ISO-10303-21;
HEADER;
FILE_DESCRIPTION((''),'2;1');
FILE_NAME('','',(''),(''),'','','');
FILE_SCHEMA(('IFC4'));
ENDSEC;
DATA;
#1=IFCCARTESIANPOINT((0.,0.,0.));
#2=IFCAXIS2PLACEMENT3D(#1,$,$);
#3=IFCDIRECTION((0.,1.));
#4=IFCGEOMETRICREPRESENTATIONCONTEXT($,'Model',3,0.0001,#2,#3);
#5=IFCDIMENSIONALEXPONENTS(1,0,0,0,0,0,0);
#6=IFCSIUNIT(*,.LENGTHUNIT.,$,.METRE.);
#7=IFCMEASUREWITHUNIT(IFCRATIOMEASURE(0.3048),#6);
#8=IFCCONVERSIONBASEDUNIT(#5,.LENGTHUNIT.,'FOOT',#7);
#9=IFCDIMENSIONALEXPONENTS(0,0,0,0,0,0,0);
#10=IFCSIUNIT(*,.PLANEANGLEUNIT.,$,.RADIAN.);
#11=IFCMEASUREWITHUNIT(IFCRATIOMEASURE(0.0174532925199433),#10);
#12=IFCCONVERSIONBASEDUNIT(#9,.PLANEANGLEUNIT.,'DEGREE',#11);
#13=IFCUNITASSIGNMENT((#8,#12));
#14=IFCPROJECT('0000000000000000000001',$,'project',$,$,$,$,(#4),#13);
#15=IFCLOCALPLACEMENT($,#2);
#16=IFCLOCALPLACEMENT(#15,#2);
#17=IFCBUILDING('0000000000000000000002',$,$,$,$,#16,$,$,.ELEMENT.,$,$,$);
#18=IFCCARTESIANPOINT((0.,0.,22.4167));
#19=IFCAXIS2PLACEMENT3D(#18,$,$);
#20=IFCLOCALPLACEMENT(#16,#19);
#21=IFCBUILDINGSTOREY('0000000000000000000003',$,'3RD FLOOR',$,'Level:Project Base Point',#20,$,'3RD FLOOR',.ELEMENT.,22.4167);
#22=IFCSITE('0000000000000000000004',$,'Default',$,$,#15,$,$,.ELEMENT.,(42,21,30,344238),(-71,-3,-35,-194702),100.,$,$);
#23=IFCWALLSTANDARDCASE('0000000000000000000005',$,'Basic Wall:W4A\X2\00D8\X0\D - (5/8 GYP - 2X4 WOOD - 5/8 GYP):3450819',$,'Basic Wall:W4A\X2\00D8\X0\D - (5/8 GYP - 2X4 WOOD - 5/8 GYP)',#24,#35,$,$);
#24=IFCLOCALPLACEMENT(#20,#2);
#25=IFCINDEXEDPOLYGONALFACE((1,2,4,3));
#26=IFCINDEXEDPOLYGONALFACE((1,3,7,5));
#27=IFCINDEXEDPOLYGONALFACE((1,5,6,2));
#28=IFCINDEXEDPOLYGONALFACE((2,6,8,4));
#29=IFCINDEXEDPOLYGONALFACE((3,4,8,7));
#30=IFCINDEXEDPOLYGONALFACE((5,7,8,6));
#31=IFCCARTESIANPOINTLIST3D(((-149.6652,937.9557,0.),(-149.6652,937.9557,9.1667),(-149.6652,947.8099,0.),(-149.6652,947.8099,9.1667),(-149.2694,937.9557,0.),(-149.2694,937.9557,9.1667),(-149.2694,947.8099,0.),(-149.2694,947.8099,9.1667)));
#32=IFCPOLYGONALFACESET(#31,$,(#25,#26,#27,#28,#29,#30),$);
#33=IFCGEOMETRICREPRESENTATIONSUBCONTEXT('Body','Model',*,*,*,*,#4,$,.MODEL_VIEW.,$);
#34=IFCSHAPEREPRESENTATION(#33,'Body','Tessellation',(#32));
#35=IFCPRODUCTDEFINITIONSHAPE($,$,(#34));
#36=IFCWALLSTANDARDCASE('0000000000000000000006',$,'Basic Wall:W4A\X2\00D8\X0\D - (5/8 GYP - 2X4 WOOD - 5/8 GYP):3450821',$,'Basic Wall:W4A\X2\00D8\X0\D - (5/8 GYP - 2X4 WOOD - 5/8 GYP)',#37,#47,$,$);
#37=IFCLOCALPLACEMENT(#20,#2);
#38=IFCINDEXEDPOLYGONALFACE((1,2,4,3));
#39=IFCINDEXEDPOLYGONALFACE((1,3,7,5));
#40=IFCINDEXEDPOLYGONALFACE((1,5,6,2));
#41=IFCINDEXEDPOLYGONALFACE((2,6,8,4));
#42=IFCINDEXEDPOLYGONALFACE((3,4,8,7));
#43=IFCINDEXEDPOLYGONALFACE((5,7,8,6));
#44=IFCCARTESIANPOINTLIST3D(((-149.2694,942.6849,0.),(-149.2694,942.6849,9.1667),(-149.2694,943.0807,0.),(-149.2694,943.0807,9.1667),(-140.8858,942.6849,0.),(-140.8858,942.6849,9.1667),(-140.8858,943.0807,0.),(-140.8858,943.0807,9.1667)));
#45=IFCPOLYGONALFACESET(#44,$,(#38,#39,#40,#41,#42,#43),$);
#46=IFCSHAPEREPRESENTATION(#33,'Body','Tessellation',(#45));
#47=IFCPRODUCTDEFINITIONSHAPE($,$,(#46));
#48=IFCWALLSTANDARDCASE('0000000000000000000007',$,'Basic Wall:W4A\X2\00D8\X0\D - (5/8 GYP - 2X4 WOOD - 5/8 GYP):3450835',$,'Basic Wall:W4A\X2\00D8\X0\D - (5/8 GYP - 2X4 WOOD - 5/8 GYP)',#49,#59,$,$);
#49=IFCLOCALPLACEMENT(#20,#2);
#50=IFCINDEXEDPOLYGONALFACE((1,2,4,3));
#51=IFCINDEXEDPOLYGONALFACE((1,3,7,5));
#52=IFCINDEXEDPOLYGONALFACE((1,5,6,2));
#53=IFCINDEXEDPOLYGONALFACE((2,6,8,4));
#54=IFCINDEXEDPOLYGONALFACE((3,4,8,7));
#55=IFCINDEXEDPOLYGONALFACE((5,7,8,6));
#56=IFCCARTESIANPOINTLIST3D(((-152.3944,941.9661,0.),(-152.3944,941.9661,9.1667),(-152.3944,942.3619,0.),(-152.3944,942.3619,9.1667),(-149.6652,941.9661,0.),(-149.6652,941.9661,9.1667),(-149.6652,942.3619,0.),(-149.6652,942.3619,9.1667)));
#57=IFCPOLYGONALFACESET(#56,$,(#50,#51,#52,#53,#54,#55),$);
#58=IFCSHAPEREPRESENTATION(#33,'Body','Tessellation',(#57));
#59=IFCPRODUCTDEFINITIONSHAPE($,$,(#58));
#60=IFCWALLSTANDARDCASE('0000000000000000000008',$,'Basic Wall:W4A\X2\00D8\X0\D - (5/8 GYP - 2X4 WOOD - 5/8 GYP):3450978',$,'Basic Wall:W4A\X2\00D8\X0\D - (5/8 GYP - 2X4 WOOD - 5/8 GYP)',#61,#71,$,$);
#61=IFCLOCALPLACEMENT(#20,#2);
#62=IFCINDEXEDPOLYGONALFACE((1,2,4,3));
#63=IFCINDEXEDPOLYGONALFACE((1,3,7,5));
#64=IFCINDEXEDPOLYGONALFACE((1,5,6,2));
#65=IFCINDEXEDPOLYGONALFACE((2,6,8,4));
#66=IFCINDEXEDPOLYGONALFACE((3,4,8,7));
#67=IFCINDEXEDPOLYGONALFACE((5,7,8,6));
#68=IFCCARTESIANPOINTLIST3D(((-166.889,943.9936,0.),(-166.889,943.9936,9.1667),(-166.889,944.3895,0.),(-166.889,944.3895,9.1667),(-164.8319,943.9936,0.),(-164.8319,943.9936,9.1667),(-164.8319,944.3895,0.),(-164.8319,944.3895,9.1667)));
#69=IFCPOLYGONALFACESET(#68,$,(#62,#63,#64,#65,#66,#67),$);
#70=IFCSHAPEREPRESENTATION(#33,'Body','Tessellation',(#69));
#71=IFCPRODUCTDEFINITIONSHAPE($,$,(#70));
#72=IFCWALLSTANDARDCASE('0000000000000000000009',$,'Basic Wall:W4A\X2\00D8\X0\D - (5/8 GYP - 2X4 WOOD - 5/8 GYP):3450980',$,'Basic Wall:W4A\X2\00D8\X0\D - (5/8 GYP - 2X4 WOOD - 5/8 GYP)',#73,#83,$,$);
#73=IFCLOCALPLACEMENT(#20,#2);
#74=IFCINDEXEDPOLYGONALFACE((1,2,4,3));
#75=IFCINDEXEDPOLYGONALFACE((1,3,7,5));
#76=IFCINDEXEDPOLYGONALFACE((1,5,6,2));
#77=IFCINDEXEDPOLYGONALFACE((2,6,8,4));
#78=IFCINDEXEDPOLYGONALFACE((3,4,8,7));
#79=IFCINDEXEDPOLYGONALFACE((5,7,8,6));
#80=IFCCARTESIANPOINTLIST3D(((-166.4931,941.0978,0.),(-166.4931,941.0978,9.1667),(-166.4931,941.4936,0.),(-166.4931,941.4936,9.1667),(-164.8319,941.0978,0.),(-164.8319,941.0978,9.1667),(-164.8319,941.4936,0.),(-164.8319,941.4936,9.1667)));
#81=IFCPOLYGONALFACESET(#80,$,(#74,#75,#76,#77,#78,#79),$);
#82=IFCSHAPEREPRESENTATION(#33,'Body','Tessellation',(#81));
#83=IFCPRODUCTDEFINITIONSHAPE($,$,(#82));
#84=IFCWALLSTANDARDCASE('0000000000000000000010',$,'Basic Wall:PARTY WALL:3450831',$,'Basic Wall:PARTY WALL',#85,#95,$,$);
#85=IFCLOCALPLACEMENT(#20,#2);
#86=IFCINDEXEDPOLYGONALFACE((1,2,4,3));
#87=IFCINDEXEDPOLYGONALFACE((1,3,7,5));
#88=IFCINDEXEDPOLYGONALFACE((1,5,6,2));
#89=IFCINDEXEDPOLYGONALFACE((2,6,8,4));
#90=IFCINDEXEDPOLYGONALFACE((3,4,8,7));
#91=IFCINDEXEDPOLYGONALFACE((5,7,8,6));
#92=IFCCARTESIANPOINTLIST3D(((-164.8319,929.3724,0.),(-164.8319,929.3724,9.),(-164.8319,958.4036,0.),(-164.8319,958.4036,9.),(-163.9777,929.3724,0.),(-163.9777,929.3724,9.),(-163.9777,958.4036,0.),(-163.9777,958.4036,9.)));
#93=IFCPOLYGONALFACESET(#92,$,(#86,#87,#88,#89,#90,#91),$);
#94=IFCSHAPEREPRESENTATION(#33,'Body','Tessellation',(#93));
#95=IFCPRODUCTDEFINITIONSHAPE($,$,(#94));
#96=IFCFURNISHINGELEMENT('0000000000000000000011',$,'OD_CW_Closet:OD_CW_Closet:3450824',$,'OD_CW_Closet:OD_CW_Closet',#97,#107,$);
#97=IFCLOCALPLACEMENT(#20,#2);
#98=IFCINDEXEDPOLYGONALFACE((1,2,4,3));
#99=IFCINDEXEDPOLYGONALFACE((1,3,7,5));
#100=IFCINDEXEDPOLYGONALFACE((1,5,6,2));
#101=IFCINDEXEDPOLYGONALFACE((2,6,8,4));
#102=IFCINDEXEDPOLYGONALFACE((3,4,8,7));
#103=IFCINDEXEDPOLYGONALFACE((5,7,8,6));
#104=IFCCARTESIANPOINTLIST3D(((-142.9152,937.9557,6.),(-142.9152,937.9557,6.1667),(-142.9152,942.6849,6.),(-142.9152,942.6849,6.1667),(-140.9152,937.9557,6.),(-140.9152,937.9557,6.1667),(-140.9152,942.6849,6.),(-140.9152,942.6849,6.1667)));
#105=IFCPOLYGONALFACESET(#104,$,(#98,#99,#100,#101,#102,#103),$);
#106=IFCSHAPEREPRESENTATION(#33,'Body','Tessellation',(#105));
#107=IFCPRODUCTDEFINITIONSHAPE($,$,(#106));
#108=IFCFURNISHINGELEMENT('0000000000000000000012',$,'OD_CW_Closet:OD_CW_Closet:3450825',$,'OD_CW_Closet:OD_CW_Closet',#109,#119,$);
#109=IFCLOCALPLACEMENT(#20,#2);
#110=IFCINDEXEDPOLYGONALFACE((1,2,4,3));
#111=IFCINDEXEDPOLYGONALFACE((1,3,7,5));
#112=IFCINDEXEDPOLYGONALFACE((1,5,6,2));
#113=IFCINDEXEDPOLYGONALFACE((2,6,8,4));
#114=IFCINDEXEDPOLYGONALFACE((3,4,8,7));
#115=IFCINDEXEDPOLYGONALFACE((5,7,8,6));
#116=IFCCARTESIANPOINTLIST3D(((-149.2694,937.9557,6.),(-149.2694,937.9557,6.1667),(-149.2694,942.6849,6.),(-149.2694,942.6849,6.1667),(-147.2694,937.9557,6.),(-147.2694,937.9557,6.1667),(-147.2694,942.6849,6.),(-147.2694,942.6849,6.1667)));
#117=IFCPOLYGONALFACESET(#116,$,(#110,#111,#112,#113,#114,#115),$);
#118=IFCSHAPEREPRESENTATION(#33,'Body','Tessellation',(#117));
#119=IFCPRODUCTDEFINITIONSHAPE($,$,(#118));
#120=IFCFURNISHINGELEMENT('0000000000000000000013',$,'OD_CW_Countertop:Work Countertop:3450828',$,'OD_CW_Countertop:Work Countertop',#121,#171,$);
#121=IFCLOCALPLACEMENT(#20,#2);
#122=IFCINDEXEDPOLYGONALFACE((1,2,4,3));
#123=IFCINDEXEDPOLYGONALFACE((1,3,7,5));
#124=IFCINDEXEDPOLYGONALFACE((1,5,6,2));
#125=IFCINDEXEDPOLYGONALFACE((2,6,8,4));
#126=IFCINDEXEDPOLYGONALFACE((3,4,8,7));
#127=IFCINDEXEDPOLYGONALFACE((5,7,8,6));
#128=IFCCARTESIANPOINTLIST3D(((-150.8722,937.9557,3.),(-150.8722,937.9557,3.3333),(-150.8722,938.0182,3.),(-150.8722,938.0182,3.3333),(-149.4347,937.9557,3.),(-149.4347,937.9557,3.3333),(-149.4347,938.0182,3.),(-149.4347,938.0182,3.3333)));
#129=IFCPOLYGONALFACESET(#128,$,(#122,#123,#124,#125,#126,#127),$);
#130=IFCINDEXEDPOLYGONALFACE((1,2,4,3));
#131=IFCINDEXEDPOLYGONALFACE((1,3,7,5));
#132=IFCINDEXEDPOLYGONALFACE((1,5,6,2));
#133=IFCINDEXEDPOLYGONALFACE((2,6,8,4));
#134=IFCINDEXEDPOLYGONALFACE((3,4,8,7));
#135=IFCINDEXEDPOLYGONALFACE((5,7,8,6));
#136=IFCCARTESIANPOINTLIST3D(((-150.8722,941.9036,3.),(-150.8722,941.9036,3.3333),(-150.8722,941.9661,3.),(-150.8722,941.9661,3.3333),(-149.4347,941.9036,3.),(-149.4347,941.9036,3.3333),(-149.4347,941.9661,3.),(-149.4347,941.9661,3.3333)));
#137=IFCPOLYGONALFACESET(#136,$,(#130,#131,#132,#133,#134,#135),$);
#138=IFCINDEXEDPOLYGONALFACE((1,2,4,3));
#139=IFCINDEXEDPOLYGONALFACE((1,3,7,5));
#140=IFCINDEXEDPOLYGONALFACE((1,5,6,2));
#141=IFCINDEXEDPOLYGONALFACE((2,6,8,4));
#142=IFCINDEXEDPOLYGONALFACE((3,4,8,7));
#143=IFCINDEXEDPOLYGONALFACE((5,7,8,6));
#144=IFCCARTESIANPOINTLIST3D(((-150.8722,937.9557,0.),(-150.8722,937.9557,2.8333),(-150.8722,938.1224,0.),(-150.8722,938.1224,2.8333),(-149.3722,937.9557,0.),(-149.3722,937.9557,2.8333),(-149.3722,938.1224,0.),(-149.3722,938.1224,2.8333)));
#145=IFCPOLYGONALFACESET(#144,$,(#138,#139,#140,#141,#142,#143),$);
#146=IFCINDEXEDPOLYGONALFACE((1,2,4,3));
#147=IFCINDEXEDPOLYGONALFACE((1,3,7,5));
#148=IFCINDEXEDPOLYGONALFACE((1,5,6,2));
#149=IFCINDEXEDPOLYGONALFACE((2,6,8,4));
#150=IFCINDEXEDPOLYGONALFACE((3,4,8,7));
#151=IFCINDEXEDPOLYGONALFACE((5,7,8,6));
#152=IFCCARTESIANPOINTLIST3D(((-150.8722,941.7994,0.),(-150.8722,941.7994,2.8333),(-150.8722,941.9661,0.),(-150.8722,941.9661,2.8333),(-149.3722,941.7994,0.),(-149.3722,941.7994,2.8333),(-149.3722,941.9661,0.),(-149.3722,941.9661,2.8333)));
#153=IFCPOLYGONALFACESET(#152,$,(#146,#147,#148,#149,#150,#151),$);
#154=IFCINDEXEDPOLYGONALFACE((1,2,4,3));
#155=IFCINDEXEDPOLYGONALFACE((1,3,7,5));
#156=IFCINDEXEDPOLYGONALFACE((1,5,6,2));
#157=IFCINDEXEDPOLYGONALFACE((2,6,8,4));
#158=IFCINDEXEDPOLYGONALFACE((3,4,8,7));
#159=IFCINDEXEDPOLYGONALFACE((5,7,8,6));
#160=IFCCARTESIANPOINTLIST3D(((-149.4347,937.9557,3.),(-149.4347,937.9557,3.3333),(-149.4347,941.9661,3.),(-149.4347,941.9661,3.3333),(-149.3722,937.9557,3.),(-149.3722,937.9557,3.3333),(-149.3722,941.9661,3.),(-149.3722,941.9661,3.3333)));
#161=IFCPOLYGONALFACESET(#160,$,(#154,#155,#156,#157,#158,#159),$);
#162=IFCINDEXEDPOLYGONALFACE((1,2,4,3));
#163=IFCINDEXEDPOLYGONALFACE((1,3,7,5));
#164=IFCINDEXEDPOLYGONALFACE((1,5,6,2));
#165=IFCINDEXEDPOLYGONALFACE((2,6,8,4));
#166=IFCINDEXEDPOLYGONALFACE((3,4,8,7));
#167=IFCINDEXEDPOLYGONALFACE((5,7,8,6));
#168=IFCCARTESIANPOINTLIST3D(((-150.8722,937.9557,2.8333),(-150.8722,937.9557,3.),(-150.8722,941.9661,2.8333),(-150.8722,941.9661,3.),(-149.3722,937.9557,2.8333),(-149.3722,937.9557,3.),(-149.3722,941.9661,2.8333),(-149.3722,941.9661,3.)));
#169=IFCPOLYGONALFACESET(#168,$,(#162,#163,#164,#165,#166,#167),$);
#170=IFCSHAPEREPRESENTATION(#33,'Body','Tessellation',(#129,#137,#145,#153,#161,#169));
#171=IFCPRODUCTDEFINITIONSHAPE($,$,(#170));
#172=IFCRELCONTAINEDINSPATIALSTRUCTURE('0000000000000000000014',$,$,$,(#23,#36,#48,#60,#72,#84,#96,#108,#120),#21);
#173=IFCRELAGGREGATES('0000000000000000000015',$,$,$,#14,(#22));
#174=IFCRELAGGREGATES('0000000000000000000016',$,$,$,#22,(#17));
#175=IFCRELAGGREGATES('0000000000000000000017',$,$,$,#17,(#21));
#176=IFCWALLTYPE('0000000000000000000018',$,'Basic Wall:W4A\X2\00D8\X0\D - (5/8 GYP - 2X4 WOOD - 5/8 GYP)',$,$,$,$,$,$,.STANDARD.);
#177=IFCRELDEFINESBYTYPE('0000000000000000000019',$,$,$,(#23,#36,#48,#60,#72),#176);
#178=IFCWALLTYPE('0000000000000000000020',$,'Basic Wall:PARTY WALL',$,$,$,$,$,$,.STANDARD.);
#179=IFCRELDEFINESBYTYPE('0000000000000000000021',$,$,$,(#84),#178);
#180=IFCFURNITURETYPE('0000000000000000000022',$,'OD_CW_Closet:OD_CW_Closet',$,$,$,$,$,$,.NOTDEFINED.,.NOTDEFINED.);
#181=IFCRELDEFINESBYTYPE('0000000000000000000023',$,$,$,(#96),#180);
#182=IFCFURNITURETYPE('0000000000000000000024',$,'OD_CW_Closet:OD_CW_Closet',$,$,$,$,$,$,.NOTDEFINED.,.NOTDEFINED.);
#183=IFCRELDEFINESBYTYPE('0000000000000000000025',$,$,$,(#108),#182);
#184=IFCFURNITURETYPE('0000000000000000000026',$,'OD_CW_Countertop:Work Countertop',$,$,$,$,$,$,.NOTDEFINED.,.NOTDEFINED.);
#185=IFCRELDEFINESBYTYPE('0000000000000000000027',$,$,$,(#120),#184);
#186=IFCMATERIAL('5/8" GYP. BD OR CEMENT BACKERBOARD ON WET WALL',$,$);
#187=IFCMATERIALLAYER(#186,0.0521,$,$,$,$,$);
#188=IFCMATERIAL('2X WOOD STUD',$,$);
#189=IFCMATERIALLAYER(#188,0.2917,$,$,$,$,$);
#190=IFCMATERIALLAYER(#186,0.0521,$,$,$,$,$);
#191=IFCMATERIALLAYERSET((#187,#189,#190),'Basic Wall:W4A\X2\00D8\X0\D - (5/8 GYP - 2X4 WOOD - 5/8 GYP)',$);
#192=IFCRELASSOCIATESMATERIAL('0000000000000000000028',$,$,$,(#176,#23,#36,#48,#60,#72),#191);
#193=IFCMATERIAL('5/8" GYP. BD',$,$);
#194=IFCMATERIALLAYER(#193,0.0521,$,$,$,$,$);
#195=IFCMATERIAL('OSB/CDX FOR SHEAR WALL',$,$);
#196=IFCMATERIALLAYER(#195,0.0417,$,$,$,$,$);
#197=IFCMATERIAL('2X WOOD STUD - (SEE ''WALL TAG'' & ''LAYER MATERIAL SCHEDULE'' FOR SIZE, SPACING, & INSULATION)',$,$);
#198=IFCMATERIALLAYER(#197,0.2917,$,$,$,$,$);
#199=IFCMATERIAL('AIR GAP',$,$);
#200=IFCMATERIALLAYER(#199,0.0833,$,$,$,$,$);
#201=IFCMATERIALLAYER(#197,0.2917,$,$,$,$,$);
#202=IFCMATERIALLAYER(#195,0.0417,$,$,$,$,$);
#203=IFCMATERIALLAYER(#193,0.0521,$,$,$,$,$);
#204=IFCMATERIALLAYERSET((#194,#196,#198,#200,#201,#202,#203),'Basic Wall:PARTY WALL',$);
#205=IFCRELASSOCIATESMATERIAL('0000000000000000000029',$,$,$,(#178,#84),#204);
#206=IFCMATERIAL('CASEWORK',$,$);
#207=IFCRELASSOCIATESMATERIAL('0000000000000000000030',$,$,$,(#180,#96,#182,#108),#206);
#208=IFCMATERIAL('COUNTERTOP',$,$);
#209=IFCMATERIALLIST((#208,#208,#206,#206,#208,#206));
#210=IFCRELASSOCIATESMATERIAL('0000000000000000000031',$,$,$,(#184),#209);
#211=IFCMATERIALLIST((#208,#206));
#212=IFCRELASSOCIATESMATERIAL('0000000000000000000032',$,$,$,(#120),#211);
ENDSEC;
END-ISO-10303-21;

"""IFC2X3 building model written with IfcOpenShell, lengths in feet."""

from ifc_helpers import new_model, entity, si_unit, converted_unit, direction, frame, frame_2d, origin, origin_2d_with_axis, place, context, subcontext, project, spatial, rectangle, extrude, source, transform, mapped, material, material_list, layer, layer_set, layer_usage, type_object, type_shapes, element, save


model = new_model("IFC2X3")

# Units and contexts
model_context = context("Model", 3, precision=0.0001, world=origin(), true_north=direction((0.0, 1.0)))
body_context = subcontext(model_context, "Body", "Model", "MODEL_VIEW")
ifc_project = project(units=[converted_unit("LENGTHUNIT", "FOOT", entity("IfcRatioMeasure", 0.3048), si_unit("LENGTHUNIT", "METRE"), dimensions=[1, 0, 0, 0, 0, 0, 0]), converted_unit("PLANEANGLEUNIT", "DEGREE", entity("IfcRatioMeasure", 0.0174532925199433), si_unit("PLANEANGLEUNIT", "RADIAN"), dimensions=[0, 0, 0, 0, 0, 0, 0])], contexts=[model_context])

# Site, building, storey
site_placement = place(None, origin())
site = spatial("IfcSite", under=ifc_project, at=site_placement, Name="Default", CompositionType="ELEMENT", RefLatitude=(42, 21, 30, 344238), RefLongitude=(-71, -3, -35, -194702), RefElevation=100.0)
building_placement = place(site_placement, origin())
building = spatial("IfcBuilding", under=site, at=building_placement, CompositionType="ELEMENT")
storey_placement = place(building_placement, frame((0.0, 0.0, 22.4167)))
storey = spatial("IfcBuildingStorey", under=building, at=storey_placement, Name="3RD FLOOR", ObjectType="Level:Project Base Point", LongName="3RD FLOOR", CompositionType="ELEMENT", Elevation=22.4167)

# Shared definitions
ifc_material_1 = material(Name="5/8\" GYP. BD OR CEMENT BACKERBOARD ON WET WALL")
ifc_layer_1 = layer(ifc_material_1, 0.0521)
ifc_material_2 = material(Name="2X WOOD STUD")
ifc_layer_2 = layer(ifc_material_2, 0.2917)
ifc_layer_3 = layer(ifc_material_1, 0.0521)
ifc_layer_set_1 = layer_set([ifc_layer_1, ifc_layer_2, ifc_layer_3], Name="Basic Wall:W4AØD - (5/8 GYP - 2X4 WOOD - 5/8 GYP)")
wall_type_1 = type_object("IfcWallType", Name="Basic Wall:W4AØD - (5/8 GYP - 2X4 WOOD - 5/8 GYP)", PredefinedType="STANDARD", material=ifc_layer_set_1)

# Walls
ifc_layer_usage_1 = layer_usage(ifc_layer_set_1, "AXIS2", "POSITIVE", -0.1979)
wall_1_placement = place(storey_placement, frame((-149.4673, 937.9557, 0.0), z_axis=(0.0, 0.0, 1.0), x_axis=(0.0, 1.0, 0.0)))
element("IfcWallStandardCase", 1, at=wall_1_placement, inside=storey, type_object=wall_type_1, material=ifc_layer_usage_1, Name="Basic Wall:W4AØD - (5/8 GYP - 2X4 WOOD - 5/8 GYP):3450819", ObjectType="Basic Wall:W4AØD - (5/8 GYP - 2X4 WOOD - 5/8 GYP)", context=body_context, shape_type="SweptSolid", body=[
    extrude(rectangle(XDim=9.8542, YDim=0.3958, at=frame_2d((4.9271, 0.0), x_axis=(-1.0, 0.0))), origin(), (0.0, 0.0, 1.0), 9.1667),
])
ifc_layer_usage_2 = layer_usage(ifc_layer_set_1, "AXIS2", "NEGATIVE", 0.1979)
wall_2_placement = place(storey_placement, frame((-149.2694, 942.8828, 0.0)))
element("IfcWallStandardCase", 2, at=wall_2_placement, inside=storey, type_object=wall_type_1, material=ifc_layer_usage_2, Name="Basic Wall:W4AØD - (5/8 GYP - 2X4 WOOD - 5/8 GYP):3450821", ObjectType="Basic Wall:W4AØD - (5/8 GYP - 2X4 WOOD - 5/8 GYP)", context=body_context, shape_type="SweptSolid", body=[
    extrude(rectangle(XDim=8.3836, YDim=0.3958, at=frame_2d((4.1918, 0.0), x_axis=(-1.0, 0.0))), origin(), (0.0, 0.0, 1.0), 9.1667),
])
ifc_layer_usage_3 = layer_usage(ifc_layer_set_1, "AXIS2", "POSITIVE", -0.1979)
wall_3_placement = place(storey_placement, frame((-149.6652, 942.164, 0.0), z_axis=(0.0, 0.0, 1.0), x_axis=(-1.0, 0.0, 0.0)))
element("IfcWallStandardCase", 3, at=wall_3_placement, inside=storey, type_object=wall_type_1, material=ifc_layer_usage_3, Name="Basic Wall:W4AØD - (5/8 GYP - 2X4 WOOD - 5/8 GYP):3450835", ObjectType="Basic Wall:W4AØD - (5/8 GYP - 2X4 WOOD - 5/8 GYP)", context=body_context, shape_type="SweptSolid", body=[
    extrude(rectangle(XDim=2.7292, YDim=0.3958, at=frame_2d((1.3646, 0.0), x_axis=(-1.0, 0.0))), origin(), (0.0, 0.0, 1.0), 9.1667),
])
ifc_layer_usage_4 = layer_usage(ifc_layer_set_1, "AXIS2", "POSITIVE", -0.1979)
wall_4_placement = place(storey_placement, frame((-164.8319, 944.1916, 0.0), z_axis=(0.0, 0.0, 1.0), x_axis=(-1.0, 0.0, 0.0)))
element("IfcWallStandardCase", 4, at=wall_4_placement, inside=storey, type_object=wall_type_1, material=ifc_layer_usage_4, Name="Basic Wall:W4AØD - (5/8 GYP - 2X4 WOOD - 5/8 GYP):3450978", ObjectType="Basic Wall:W4AØD - (5/8 GYP - 2X4 WOOD - 5/8 GYP)", context=body_context, shape_type="SweptSolid", body=[
    extrude(rectangle(XDim=2.0571, YDim=0.3958, at=frame_2d((1.0285, 0.0), x_axis=(-1.0, 0.0))), origin(), (0.0, 0.0, 1.0), 9.1667),
])

# Walls
ifc_layer_usage_5 = layer_usage(ifc_layer_set_1, "AXIS2", "POSITIVE", -0.1979)
wall_5_placement = place(storey_placement, frame((-166.4931, 941.2957, 0.0)))
element("IfcWallStandardCase", 5, at=wall_5_placement, inside=storey, type_object=wall_type_1, material=ifc_layer_usage_5, Name="Basic Wall:W4AØD - (5/8 GYP - 2X4 WOOD - 5/8 GYP):3450980", ObjectType="Basic Wall:W4AØD - (5/8 GYP - 2X4 WOOD - 5/8 GYP)", context=body_context, shape_type="SweptSolid", body=[
    extrude(rectangle(XDim=1.6612, YDim=0.3958, at=frame_2d((0.8306, 0.0), x_axis=(-1.0, 0.0))), origin(), (0.0, 0.0, 1.0), 9.1667),
])
ifc_material_3 = material(Name="5/8\" GYP. BD")
ifc_layer_4 = layer(ifc_material_3, 0.0521)
ifc_material_4 = material(Name="OSB/CDX FOR SHEAR WALL")
ifc_layer_5 = layer(ifc_material_4, 0.0417)
ifc_material_5 = material(Name="2X WOOD STUD - (SEE 'WALL TAG' & 'LAYER MATERIAL SCHEDULE' FOR SIZE, SPACING, & INSULATION)")
ifc_layer_6 = layer(ifc_material_5, 0.2917)
ifc_material_6 = material(Name="AIR GAP")
ifc_layer_7 = layer(ifc_material_6, 0.0833)
ifc_layer_8 = layer(ifc_material_5, 0.2917)
ifc_layer_9 = layer(ifc_material_4, 0.0417)
ifc_layer_10 = layer(ifc_material_3, 0.0521)
ifc_layer_set_2 = layer_set([ifc_layer_4, ifc_layer_5, ifc_layer_6, ifc_layer_7, ifc_layer_8, ifc_layer_9, ifc_layer_10], Name="Basic Wall:PARTY WALL")
ifc_layer_usage_6 = layer_usage(ifc_layer_set_2, "AXIS2", "NEGATIVE", 0.4271)
wall_type_2 = type_object("IfcWallType", Name="Basic Wall:PARTY WALL", PredefinedType="STANDARD", material=ifc_layer_set_2)
wall_6_placement = place(storey_placement, frame((-164.4048, 929.3724, 0.0), z_axis=(0.0, 0.0, 1.0), x_axis=(0.0, 1.0, 0.0)))
element("IfcWallStandardCase", 6, at=wall_6_placement, inside=storey, type_object=wall_type_2, material=ifc_layer_usage_6, Name="Basic Wall:PARTY WALL:3450831", ObjectType="Basic Wall:PARTY WALL", context=body_context, shape_type="SweptSolid", body=[
    extrude(rectangle(XDim=29.0313, YDim=0.8542, at=frame_2d((14.5156, 0.0), x_axis=(-1.0, 0.0))), origin(), (0.0, 0.0, 1.0), 9.0),
])

# Furnishing elements
ifc_material_7 = material(Name="CASEWORK")
furniture_type_1 = type_object("IfcFurnitureType", Name="OD_CW_Closet:OD_CW_Closet", material=ifc_material_7)
shared_shape_1 = source(origin(), body_context, "Body", "SweptSolid", [
    extrude(rectangle(XDim=4.7292, YDim=2.0, at=origin_2d_with_axis()), frame((2.3646, 1.0, 0.0)), (0.0, 0.0, 1.0), 0.1667),
])
type_shapes(furniture_type_1, [shared_shape_1])
furnishing_1_placement = place(storey_placement, frame((-140.9152, 937.9557, 6.0), z_axis=(0.0, 0.0, 1.0), x_axis=(0.0, 1.0, 0.0)))
element("IfcFurnishingElement", 7, at=furnishing_1_placement, inside=storey, type_object=furniture_type_1, material=ifc_material_7, Name="OD_CW_Closet:OD_CW_Closet:3450824", ObjectType="OD_CW_Closet:OD_CW_Closet", context=body_context, shape_type="MappedRepresentation", body=[
    mapped(shared_shape_1, transform((0.0, 0.0, 0.0), scale=1.0)),
])
furniture_type_2 = type_object("IfcFurnitureType", Name="OD_CW_Closet:OD_CW_Closet", material=ifc_material_7)
shared_shape_2 = source(origin(), body_context, "Body", "SweptSolid", [
    extrude(rectangle(XDim=2.0, YDim=4.7292, at=origin_2d_with_axis()), frame((2.3646, 1.0, 0.0), z_axis=(0.0, 0.0, 1.0), x_axis=(0.0, -1.0, 0.0)), (0.0, 0.0, 1.0), 0.1667),
])
type_shapes(furniture_type_2, [shared_shape_2])
furnishing_2_placement = place(storey_placement, frame((-147.2694, 937.9557, 6.0), z_axis=(0.0, 0.0, 1.0), x_axis=(0.0, 1.0, 0.0)))
element("IfcFurnishingElement", 8, at=furnishing_2_placement, inside=storey, type_object=furniture_type_2, material=ifc_material_7, Name="OD_CW_Closet:OD_CW_Closet:3450825", ObjectType="OD_CW_Closet:OD_CW_Closet", context=body_context, shape_type="MappedRepresentation", body=[
    mapped(shared_shape_2, transform((0.0, 0.0, 0.0), scale=1.0)),
])
ifc_material_8 = material(Name="COUNTERTOP")
ifc_material_list_1 = material_list([ifc_material_8, ifc_material_7])
ifc_material_list_2 = material_list([ifc_material_8, ifc_material_8, ifc_material_7, ifc_material_7, ifc_material_8, ifc_material_7])
furniture_type_3 = type_object("IfcFurnitureType", Name="OD_CW_Countertop:Work Countertop", material=ifc_material_list_2)
shared_shape_3 = source(origin(), body_context, "Body", "SweptSolid", [
    extrude(rectangle(XDim=0.0625, YDim=1.4375, at=origin_2d_with_axis()), frame((3.9792, 0.7188, 3.0), z_axis=(0.0, 0.0, 1.0), x_axis=(-1.0, 0.0, 0.0)), (0.0, 0.0, 1.0), 0.3333),
    extrude(rectangle(XDim=0.0625, YDim=1.4375, at=origin_2d_with_axis()), frame((0.0313, 0.7188, 3.0), z_axis=(0.0, 0.0, 1.0), x_axis=(-1.0, 0.0, 0.0)), (0.0, 0.0, 1.0), 0.3333),
    extrude(rectangle(XDim=1.5, YDim=0.1667, at=frame_2d((0.0, 0.0), x_axis=(1.0, 0.0))), frame((3.9271, 0.75, 0.0), z_axis=(0.0, 0.0, 1.0), x_axis=(0.0, -1.0, 0.0)), (0.0, 0.0, 1.0), 2.8333),
    extrude(rectangle(XDim=1.5, YDim=0.1667, at=origin_2d_with_axis()), frame((0.0833, 0.75, 0.0), z_axis=(0.0, 0.0, 1.0), x_axis=(0.0, -1.0, 0.0)), (0.0, 0.0, 1.0), 2.8333),
    extrude(rectangle(XDim=0.0625, YDim=4.0104, at=frame_2d((0.0, 0.0), x_axis=(1.0, 0.0))), frame((2.0052, 1.4688, 3.0), z_axis=(0.0, 0.0, 1.0), x_axis=(0.0, -1.0, 0.0)), (0.0, 0.0, 1.0), 0.3333),
    extrude(rectangle(XDim=1.5, YDim=4.0104, at=frame_2d((0.0, 0.0), x_axis=(1.0, 0.0))), frame((2.0052, 0.75, 2.8333), z_axis=(0.0, 0.0, 1.0), x_axis=(0.0, -1.0, 0.0)), (0.0, 0.0, 1.0), 0.1667),
])
type_shapes(furniture_type_3, [shared_shape_3])
furnishing_3_placement = place(storey_placement, frame((-150.8722, 941.9661, 0.0), z_axis=(0.0, 0.0, 1.0), x_axis=(0.0, -1.0, 0.0)))
element("IfcFurnishingElement", 9, at=furnishing_3_placement, inside=storey, type_object=furniture_type_3, material=ifc_material_list_1, Name="OD_CW_Countertop:Work Countertop:3450828", ObjectType="OD_CW_Countertop:Work Countertop", context=body_context, shape_type="MappedRepresentation", body=[
    mapped(shared_shape_3, transform((0.0, 0.0, 0.0), scale=1.0)),
])

save(model, "model.ifc")
